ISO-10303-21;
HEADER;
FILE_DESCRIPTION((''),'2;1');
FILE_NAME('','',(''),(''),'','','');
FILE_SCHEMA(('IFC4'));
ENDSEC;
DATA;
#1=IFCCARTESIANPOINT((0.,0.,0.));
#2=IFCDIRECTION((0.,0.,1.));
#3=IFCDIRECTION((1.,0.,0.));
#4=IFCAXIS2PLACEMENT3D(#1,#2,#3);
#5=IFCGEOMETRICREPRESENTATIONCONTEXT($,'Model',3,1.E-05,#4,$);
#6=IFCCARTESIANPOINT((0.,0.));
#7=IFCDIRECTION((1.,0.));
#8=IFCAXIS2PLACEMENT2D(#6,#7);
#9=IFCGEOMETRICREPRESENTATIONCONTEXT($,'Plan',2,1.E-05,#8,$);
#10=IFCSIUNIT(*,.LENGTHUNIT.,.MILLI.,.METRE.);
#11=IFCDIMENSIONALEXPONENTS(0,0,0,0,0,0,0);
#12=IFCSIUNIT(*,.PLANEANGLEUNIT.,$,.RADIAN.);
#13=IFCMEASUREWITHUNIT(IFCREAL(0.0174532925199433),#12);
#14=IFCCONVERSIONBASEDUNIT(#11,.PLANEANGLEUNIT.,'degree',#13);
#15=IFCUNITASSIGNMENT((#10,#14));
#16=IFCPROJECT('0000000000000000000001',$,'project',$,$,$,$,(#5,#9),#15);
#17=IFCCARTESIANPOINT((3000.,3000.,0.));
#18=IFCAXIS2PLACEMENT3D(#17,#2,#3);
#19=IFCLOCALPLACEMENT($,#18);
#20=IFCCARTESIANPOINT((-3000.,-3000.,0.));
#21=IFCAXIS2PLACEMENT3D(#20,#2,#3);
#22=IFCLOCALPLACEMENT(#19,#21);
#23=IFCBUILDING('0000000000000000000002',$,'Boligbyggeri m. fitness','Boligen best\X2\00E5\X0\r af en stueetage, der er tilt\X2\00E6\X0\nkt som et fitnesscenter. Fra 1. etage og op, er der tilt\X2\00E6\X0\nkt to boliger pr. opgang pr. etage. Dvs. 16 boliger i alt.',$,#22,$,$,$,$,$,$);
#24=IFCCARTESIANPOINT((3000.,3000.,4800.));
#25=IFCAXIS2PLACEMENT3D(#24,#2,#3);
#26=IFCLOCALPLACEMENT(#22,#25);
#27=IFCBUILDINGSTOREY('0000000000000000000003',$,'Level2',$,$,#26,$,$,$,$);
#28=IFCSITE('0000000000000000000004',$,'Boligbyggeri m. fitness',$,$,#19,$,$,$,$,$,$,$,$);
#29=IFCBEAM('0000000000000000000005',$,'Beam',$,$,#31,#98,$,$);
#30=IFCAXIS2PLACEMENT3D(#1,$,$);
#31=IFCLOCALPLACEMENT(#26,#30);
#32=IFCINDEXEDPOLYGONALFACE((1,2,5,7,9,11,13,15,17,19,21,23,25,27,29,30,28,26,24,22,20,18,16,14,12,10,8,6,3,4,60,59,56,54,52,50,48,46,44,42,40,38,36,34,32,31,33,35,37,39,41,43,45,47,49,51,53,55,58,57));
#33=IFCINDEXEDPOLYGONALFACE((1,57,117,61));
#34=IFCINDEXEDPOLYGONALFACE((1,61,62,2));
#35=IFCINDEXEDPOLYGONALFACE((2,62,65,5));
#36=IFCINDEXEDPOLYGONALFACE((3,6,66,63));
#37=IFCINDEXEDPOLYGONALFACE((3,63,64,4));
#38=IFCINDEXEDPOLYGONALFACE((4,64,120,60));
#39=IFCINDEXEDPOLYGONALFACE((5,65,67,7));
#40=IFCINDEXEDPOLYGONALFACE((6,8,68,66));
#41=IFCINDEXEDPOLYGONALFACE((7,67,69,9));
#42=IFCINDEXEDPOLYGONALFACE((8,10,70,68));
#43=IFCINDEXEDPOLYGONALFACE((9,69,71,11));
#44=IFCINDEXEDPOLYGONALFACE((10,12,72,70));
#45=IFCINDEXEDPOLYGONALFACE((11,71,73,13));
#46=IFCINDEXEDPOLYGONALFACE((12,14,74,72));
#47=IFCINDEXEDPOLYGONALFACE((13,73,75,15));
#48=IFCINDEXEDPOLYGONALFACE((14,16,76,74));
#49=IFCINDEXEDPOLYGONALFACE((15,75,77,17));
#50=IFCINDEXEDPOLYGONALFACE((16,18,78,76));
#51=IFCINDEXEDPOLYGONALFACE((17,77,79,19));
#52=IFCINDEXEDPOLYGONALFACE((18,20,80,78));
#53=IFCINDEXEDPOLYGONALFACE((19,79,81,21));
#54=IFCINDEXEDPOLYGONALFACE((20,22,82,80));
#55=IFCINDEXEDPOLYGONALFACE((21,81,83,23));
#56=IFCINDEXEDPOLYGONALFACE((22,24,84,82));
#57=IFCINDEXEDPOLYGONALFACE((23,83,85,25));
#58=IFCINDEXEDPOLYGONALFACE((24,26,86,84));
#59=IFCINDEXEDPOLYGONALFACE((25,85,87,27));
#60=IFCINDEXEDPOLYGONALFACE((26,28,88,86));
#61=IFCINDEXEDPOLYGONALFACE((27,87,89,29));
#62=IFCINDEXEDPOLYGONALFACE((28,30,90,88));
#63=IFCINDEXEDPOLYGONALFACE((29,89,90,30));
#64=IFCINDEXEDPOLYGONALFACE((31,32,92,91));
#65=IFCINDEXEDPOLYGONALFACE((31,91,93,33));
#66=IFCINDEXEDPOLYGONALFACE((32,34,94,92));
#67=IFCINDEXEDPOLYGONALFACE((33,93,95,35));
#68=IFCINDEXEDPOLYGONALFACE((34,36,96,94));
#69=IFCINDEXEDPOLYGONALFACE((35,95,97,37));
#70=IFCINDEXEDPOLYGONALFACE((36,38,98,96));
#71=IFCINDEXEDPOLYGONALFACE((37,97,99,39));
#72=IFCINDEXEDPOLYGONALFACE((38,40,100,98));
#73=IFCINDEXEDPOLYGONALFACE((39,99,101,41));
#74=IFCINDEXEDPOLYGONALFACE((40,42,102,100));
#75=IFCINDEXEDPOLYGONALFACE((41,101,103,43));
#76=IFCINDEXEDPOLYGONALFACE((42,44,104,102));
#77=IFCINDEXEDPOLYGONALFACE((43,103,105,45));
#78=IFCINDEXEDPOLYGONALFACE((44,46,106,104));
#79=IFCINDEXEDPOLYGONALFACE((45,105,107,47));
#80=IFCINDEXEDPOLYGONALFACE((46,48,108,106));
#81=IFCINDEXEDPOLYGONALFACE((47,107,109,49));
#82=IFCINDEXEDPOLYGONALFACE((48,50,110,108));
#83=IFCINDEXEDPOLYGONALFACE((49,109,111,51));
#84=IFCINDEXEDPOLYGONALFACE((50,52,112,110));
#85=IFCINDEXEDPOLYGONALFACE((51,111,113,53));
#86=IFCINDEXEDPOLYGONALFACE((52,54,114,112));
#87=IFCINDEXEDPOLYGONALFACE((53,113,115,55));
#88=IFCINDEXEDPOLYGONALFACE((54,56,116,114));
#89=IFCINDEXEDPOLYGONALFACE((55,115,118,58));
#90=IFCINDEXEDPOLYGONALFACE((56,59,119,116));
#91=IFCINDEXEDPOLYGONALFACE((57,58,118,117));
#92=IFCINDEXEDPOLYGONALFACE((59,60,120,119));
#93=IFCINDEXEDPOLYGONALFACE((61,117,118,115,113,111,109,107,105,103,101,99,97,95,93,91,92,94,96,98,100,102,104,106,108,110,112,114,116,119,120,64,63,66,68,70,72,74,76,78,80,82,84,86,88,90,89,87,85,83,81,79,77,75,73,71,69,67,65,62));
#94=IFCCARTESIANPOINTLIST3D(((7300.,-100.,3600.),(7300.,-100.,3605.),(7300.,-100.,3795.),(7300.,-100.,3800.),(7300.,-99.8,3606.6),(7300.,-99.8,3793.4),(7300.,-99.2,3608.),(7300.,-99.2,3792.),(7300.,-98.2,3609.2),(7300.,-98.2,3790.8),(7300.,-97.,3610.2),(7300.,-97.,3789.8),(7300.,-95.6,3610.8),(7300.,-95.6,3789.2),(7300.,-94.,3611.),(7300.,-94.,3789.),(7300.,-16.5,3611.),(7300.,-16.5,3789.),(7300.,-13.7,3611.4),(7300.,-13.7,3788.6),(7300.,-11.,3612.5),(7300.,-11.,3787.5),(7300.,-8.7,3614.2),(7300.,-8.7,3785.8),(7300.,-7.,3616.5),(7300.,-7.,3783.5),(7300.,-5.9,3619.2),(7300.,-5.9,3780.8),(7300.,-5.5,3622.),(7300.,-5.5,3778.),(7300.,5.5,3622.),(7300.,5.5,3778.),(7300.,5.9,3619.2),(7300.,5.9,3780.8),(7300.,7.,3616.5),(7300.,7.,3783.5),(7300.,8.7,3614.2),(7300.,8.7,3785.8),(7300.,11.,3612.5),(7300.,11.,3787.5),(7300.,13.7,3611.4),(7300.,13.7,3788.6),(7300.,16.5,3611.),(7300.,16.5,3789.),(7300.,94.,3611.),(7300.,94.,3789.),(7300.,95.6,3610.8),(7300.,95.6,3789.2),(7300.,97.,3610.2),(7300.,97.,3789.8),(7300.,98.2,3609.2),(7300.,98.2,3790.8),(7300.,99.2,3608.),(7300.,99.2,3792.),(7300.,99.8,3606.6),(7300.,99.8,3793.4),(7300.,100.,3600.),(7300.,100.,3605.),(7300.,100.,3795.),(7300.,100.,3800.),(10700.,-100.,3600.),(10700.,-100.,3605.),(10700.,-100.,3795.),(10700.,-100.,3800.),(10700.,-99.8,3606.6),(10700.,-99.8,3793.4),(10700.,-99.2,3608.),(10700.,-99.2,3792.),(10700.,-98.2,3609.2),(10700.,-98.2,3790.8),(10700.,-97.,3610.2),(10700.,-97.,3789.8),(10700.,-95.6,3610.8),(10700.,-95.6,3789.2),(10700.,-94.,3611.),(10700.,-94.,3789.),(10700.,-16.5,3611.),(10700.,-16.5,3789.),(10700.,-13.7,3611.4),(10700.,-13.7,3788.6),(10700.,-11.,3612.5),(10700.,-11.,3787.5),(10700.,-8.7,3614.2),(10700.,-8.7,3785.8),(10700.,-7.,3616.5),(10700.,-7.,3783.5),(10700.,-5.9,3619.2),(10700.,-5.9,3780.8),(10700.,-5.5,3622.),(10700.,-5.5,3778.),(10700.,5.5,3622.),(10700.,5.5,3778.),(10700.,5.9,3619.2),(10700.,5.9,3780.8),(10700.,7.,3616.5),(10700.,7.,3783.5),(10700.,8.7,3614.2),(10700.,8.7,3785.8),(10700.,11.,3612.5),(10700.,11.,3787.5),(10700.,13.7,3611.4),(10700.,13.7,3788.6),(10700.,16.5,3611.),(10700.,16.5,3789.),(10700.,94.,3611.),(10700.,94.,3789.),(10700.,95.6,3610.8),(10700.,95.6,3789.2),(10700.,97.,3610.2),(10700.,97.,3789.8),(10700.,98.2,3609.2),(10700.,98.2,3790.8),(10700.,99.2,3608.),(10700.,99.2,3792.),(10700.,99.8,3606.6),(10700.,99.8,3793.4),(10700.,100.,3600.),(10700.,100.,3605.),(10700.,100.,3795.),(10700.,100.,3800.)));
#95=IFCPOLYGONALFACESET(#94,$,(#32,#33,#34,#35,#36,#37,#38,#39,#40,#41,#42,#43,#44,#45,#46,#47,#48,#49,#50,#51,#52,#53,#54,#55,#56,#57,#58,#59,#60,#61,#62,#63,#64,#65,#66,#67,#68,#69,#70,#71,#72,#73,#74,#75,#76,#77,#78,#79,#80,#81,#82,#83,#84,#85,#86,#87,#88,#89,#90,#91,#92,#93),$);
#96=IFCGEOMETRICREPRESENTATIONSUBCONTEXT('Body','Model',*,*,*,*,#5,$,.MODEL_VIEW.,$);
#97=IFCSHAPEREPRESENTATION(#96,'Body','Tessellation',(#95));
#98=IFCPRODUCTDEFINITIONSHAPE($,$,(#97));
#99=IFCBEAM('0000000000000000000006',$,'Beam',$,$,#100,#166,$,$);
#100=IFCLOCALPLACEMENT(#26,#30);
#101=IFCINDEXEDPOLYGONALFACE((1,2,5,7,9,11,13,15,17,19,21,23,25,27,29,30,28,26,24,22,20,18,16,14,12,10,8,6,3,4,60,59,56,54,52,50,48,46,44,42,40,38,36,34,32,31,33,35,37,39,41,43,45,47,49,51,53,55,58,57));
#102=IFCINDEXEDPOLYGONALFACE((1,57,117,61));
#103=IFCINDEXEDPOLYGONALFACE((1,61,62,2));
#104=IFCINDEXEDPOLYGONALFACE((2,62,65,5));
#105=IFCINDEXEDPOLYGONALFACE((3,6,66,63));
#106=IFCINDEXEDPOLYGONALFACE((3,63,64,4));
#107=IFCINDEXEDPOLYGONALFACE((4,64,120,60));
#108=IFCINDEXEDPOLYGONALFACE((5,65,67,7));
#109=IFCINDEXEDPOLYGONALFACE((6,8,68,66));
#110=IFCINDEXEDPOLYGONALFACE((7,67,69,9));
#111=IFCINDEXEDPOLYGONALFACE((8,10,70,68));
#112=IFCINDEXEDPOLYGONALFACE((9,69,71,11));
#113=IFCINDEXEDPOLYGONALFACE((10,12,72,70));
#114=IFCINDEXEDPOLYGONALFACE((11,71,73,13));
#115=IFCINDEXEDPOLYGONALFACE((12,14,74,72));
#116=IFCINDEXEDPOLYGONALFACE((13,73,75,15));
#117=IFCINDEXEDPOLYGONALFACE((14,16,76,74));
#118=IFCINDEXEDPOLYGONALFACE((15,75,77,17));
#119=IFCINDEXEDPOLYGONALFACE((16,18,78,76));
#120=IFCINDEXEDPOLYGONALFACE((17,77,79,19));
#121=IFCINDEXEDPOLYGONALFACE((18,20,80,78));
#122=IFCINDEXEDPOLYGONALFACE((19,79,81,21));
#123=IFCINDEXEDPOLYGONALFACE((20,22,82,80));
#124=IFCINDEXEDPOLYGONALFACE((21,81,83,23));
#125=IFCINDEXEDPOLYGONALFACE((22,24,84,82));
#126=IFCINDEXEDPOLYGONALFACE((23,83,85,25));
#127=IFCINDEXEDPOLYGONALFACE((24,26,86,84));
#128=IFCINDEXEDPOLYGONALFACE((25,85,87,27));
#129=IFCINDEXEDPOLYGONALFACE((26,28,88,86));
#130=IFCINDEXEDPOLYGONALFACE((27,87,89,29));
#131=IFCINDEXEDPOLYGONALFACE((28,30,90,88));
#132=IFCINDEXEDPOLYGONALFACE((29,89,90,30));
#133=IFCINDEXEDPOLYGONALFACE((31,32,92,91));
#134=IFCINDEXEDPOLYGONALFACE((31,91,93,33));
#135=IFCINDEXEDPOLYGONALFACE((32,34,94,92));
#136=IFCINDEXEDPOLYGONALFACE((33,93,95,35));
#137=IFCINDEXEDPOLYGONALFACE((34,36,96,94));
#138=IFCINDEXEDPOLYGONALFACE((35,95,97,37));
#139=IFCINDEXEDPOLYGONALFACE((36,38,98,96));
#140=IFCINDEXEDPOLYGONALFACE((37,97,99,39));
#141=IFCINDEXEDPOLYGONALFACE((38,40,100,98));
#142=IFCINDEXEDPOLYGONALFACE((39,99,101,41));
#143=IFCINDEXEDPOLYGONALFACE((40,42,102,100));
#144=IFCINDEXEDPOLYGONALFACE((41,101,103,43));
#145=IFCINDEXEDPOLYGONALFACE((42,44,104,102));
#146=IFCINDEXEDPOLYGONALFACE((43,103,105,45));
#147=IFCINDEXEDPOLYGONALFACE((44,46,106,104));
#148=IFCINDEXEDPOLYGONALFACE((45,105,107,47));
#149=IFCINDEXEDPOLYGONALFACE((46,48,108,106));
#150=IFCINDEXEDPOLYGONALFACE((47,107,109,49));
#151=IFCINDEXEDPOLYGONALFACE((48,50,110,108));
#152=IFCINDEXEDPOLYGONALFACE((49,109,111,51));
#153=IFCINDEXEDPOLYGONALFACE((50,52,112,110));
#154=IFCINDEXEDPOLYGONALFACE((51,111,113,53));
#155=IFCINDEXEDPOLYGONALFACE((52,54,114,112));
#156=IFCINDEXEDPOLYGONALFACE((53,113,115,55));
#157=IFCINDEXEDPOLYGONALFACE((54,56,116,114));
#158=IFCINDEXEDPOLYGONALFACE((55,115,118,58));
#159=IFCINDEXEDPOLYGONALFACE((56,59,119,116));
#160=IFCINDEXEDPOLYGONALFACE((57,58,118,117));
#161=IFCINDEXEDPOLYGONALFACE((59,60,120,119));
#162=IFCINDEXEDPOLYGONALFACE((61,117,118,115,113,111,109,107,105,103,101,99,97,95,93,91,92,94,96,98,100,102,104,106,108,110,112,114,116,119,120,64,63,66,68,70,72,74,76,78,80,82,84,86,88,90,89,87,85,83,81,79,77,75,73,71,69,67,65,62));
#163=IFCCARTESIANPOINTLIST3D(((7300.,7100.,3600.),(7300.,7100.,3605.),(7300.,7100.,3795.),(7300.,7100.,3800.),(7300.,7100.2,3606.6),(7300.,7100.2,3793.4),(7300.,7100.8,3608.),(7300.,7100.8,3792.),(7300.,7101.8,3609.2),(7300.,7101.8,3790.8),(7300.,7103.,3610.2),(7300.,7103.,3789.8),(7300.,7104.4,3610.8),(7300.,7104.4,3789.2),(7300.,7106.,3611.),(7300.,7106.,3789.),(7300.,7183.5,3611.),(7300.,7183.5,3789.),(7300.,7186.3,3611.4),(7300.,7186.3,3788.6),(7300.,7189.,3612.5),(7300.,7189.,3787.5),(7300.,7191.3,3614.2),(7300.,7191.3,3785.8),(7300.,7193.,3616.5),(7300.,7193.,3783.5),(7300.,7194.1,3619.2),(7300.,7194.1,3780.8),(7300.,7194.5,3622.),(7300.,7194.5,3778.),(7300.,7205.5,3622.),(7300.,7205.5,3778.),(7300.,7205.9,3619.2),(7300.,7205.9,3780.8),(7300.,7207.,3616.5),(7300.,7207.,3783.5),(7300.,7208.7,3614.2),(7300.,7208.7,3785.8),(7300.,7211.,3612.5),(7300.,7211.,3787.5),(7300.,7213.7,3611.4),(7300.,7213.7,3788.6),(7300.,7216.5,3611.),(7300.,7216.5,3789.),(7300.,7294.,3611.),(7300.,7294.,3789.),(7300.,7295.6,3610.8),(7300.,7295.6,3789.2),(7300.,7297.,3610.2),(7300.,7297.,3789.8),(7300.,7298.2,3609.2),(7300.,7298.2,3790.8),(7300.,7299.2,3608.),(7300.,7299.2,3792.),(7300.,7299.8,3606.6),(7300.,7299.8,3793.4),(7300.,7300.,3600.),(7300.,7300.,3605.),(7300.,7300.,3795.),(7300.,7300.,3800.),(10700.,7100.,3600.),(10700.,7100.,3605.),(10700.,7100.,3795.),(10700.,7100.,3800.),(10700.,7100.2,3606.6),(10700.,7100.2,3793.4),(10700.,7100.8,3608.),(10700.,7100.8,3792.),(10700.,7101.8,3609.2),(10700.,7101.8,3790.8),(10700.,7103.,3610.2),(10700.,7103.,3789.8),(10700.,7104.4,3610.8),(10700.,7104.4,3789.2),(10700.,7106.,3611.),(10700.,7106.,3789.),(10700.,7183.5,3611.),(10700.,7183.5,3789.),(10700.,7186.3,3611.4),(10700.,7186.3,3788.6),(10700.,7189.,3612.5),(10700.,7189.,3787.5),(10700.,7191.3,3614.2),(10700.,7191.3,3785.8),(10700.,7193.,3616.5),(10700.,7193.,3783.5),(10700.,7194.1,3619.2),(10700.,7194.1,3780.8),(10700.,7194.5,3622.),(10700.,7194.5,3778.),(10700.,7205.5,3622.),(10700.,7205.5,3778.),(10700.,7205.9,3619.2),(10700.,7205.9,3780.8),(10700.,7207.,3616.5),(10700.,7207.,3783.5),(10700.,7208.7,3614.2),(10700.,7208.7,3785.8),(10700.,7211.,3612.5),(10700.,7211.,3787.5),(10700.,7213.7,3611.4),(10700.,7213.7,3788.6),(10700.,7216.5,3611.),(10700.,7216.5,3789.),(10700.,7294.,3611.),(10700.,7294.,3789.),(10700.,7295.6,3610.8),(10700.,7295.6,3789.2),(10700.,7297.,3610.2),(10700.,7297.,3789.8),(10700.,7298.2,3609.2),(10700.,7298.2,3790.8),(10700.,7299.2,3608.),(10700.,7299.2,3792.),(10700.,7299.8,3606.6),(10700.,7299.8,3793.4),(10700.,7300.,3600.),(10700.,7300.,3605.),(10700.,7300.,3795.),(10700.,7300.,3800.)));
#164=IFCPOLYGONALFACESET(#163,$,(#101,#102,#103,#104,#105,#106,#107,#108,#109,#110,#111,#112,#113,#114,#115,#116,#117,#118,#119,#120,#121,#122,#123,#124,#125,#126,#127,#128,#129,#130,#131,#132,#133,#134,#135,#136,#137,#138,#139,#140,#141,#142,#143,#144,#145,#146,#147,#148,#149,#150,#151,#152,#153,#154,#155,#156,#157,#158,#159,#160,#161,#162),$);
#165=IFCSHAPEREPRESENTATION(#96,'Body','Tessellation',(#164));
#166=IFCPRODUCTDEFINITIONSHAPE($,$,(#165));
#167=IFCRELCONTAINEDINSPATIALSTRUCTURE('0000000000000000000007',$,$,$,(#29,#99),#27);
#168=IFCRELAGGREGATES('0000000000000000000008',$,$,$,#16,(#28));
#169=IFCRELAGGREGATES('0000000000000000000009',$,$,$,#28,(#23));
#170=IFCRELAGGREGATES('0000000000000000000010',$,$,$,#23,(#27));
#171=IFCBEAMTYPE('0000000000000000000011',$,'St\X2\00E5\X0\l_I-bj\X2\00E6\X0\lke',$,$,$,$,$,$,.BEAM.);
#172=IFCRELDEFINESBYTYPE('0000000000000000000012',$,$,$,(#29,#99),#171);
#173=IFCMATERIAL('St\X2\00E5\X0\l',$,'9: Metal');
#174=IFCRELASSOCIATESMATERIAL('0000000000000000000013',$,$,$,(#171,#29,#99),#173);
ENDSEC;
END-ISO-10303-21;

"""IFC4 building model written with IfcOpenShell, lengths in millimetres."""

from ifc_helpers import new_model, entity, si_unit, converted_unit, frame, origin_with_axes, origin_2d_with_axis, place, context, subcontext, project, spatial, i_section, extrude, material, material_profile, profile_set, profile_usage, type_object, element, save


model = new_model("IFC4")

# Units and contexts
model_context = context("Model", 3, precision=1e-05, world=origin_with_axes())
plan_context = context("Plan", 2, precision=1e-05, world=origin_2d_with_axis())
body_context = subcontext(model_context, "Body", "Model", "MODEL_VIEW")
ifc_project = project(units=[si_unit("LENGTHUNIT", "METRE", prefix="MILLI"), converted_unit("PLANEANGLEUNIT", "degree", entity("IfcReal", 0.0174532925199433), si_unit("PLANEANGLEUNIT", "RADIAN"), dimensions=[0, 0, 0, 0, 0, 0, 0])], contexts=[model_context, plan_context])

# Site, building, storey
site_placement = place(None, frame((3000.0, 3000.0, 0.0), z_axis=(0.0, 0.0, 1.0), x_axis=(1.0, 0.0, 0.0)))
site = spatial("IfcSite", under=ifc_project, at=site_placement, Name="Boligbyggeri m. fitness")
building_placement = place(site_placement, frame((-3000.0, -3000.0, 0.0), z_axis=(0.0, 0.0, 1.0), x_axis=(1.0, 0.0, 0.0)))
building = spatial("IfcBuilding", under=site, at=building_placement, Name="Boligbyggeri m. fitness", Description="Boligen består af en stueetage, der er tiltænkt som et fitnesscenter. Fra 1. etage og op, er der tiltænkt to boliger pr. opgang pr. etage. Dvs. 16 boliger i alt.")
storey_placement = place(building_placement, frame((3000.0, 3000.0, 4800.0), z_axis=(0.0, 0.0, 1.0), x_axis=(1.0, 0.0, 0.0)))
storey = spatial("IfcBuildingStorey", under=building, at=storey_placement, Name="Level2")

# Beams
ifc_material_1 = material(Name="Stål", Category="9: Metal")
ifc_material_profile_1 = material_profile(ifc_material_1, i_section(OverallWidth=200.0, OverallDepth=200.0, WebThickness=11.0, FlangeThickness=11.0, FilletRadius=11.0, FlangeEdgeRadius=6.0), Name="Stål", Category="9: Metal")
ifc_profile_set_1 = profile_set([ifc_material_profile_1], Name="NY_I-Profil")
beam_type = type_object("IfcBeamType", Name="Stål_I-bjælke", PredefinedType="BEAM", material=ifc_profile_set_1)
ifc_profile_usage_1 = profile_usage(ifc_profile_set_1, cardinal=7)
beam_1_placement = place(storey_placement, frame((7300.0, 100.0, 3800.0), z_axis=(1.0, 0.0, 0.0), x_axis=(0.0, 1.0, 0.0)))
element("IfcBeam", 1, at=beam_1_placement, inside=storey, type_object=beam_type, material=ifc_profile_usage_1, Name="Beam", context=body_context, shape_type="SweptSolid", body=[
    extrude(i_section(OverallWidth=200.0, OverallDepth=200.0, WebThickness=11.0, FlangeThickness=11.0, FilletRadius=11.0, FlangeEdgeRadius=6.0), frame((-100.0, -100.0, 0.0), z_axis=(0.0, 0.0, 1.0), x_axis=(1.0, 0.0, 0.0)), (0.0, 0.0, 1.0), 3400.0),
])
ifc_profile_usage_2 = profile_usage(ifc_profile_set_1, cardinal=7)
beam_2_placement = place(storey_placement, frame((7300.0, 7300.0, 3800.0), z_axis=(1.0, 0.0, 0.0), x_axis=(0.0, 1.0, 0.0)))
element("IfcBeam", 2, at=beam_2_placement, inside=storey, type_object=beam_type, material=ifc_profile_usage_2, Name="Beam", context=body_context, shape_type="SweptSolid", body=[
    extrude(i_section(OverallWidth=200.0, OverallDepth=200.0, WebThickness=11.0, FlangeThickness=11.0, FilletRadius=11.0, FlangeEdgeRadius=6.0), frame((-100.0, -100.0, 0.0), z_axis=(0.0, 0.0, 1.0), x_axis=(1.0, 0.0, 0.0)), (0.0, 0.0, 1.0), 3400.0),
])

save(model, "model.ifc")
